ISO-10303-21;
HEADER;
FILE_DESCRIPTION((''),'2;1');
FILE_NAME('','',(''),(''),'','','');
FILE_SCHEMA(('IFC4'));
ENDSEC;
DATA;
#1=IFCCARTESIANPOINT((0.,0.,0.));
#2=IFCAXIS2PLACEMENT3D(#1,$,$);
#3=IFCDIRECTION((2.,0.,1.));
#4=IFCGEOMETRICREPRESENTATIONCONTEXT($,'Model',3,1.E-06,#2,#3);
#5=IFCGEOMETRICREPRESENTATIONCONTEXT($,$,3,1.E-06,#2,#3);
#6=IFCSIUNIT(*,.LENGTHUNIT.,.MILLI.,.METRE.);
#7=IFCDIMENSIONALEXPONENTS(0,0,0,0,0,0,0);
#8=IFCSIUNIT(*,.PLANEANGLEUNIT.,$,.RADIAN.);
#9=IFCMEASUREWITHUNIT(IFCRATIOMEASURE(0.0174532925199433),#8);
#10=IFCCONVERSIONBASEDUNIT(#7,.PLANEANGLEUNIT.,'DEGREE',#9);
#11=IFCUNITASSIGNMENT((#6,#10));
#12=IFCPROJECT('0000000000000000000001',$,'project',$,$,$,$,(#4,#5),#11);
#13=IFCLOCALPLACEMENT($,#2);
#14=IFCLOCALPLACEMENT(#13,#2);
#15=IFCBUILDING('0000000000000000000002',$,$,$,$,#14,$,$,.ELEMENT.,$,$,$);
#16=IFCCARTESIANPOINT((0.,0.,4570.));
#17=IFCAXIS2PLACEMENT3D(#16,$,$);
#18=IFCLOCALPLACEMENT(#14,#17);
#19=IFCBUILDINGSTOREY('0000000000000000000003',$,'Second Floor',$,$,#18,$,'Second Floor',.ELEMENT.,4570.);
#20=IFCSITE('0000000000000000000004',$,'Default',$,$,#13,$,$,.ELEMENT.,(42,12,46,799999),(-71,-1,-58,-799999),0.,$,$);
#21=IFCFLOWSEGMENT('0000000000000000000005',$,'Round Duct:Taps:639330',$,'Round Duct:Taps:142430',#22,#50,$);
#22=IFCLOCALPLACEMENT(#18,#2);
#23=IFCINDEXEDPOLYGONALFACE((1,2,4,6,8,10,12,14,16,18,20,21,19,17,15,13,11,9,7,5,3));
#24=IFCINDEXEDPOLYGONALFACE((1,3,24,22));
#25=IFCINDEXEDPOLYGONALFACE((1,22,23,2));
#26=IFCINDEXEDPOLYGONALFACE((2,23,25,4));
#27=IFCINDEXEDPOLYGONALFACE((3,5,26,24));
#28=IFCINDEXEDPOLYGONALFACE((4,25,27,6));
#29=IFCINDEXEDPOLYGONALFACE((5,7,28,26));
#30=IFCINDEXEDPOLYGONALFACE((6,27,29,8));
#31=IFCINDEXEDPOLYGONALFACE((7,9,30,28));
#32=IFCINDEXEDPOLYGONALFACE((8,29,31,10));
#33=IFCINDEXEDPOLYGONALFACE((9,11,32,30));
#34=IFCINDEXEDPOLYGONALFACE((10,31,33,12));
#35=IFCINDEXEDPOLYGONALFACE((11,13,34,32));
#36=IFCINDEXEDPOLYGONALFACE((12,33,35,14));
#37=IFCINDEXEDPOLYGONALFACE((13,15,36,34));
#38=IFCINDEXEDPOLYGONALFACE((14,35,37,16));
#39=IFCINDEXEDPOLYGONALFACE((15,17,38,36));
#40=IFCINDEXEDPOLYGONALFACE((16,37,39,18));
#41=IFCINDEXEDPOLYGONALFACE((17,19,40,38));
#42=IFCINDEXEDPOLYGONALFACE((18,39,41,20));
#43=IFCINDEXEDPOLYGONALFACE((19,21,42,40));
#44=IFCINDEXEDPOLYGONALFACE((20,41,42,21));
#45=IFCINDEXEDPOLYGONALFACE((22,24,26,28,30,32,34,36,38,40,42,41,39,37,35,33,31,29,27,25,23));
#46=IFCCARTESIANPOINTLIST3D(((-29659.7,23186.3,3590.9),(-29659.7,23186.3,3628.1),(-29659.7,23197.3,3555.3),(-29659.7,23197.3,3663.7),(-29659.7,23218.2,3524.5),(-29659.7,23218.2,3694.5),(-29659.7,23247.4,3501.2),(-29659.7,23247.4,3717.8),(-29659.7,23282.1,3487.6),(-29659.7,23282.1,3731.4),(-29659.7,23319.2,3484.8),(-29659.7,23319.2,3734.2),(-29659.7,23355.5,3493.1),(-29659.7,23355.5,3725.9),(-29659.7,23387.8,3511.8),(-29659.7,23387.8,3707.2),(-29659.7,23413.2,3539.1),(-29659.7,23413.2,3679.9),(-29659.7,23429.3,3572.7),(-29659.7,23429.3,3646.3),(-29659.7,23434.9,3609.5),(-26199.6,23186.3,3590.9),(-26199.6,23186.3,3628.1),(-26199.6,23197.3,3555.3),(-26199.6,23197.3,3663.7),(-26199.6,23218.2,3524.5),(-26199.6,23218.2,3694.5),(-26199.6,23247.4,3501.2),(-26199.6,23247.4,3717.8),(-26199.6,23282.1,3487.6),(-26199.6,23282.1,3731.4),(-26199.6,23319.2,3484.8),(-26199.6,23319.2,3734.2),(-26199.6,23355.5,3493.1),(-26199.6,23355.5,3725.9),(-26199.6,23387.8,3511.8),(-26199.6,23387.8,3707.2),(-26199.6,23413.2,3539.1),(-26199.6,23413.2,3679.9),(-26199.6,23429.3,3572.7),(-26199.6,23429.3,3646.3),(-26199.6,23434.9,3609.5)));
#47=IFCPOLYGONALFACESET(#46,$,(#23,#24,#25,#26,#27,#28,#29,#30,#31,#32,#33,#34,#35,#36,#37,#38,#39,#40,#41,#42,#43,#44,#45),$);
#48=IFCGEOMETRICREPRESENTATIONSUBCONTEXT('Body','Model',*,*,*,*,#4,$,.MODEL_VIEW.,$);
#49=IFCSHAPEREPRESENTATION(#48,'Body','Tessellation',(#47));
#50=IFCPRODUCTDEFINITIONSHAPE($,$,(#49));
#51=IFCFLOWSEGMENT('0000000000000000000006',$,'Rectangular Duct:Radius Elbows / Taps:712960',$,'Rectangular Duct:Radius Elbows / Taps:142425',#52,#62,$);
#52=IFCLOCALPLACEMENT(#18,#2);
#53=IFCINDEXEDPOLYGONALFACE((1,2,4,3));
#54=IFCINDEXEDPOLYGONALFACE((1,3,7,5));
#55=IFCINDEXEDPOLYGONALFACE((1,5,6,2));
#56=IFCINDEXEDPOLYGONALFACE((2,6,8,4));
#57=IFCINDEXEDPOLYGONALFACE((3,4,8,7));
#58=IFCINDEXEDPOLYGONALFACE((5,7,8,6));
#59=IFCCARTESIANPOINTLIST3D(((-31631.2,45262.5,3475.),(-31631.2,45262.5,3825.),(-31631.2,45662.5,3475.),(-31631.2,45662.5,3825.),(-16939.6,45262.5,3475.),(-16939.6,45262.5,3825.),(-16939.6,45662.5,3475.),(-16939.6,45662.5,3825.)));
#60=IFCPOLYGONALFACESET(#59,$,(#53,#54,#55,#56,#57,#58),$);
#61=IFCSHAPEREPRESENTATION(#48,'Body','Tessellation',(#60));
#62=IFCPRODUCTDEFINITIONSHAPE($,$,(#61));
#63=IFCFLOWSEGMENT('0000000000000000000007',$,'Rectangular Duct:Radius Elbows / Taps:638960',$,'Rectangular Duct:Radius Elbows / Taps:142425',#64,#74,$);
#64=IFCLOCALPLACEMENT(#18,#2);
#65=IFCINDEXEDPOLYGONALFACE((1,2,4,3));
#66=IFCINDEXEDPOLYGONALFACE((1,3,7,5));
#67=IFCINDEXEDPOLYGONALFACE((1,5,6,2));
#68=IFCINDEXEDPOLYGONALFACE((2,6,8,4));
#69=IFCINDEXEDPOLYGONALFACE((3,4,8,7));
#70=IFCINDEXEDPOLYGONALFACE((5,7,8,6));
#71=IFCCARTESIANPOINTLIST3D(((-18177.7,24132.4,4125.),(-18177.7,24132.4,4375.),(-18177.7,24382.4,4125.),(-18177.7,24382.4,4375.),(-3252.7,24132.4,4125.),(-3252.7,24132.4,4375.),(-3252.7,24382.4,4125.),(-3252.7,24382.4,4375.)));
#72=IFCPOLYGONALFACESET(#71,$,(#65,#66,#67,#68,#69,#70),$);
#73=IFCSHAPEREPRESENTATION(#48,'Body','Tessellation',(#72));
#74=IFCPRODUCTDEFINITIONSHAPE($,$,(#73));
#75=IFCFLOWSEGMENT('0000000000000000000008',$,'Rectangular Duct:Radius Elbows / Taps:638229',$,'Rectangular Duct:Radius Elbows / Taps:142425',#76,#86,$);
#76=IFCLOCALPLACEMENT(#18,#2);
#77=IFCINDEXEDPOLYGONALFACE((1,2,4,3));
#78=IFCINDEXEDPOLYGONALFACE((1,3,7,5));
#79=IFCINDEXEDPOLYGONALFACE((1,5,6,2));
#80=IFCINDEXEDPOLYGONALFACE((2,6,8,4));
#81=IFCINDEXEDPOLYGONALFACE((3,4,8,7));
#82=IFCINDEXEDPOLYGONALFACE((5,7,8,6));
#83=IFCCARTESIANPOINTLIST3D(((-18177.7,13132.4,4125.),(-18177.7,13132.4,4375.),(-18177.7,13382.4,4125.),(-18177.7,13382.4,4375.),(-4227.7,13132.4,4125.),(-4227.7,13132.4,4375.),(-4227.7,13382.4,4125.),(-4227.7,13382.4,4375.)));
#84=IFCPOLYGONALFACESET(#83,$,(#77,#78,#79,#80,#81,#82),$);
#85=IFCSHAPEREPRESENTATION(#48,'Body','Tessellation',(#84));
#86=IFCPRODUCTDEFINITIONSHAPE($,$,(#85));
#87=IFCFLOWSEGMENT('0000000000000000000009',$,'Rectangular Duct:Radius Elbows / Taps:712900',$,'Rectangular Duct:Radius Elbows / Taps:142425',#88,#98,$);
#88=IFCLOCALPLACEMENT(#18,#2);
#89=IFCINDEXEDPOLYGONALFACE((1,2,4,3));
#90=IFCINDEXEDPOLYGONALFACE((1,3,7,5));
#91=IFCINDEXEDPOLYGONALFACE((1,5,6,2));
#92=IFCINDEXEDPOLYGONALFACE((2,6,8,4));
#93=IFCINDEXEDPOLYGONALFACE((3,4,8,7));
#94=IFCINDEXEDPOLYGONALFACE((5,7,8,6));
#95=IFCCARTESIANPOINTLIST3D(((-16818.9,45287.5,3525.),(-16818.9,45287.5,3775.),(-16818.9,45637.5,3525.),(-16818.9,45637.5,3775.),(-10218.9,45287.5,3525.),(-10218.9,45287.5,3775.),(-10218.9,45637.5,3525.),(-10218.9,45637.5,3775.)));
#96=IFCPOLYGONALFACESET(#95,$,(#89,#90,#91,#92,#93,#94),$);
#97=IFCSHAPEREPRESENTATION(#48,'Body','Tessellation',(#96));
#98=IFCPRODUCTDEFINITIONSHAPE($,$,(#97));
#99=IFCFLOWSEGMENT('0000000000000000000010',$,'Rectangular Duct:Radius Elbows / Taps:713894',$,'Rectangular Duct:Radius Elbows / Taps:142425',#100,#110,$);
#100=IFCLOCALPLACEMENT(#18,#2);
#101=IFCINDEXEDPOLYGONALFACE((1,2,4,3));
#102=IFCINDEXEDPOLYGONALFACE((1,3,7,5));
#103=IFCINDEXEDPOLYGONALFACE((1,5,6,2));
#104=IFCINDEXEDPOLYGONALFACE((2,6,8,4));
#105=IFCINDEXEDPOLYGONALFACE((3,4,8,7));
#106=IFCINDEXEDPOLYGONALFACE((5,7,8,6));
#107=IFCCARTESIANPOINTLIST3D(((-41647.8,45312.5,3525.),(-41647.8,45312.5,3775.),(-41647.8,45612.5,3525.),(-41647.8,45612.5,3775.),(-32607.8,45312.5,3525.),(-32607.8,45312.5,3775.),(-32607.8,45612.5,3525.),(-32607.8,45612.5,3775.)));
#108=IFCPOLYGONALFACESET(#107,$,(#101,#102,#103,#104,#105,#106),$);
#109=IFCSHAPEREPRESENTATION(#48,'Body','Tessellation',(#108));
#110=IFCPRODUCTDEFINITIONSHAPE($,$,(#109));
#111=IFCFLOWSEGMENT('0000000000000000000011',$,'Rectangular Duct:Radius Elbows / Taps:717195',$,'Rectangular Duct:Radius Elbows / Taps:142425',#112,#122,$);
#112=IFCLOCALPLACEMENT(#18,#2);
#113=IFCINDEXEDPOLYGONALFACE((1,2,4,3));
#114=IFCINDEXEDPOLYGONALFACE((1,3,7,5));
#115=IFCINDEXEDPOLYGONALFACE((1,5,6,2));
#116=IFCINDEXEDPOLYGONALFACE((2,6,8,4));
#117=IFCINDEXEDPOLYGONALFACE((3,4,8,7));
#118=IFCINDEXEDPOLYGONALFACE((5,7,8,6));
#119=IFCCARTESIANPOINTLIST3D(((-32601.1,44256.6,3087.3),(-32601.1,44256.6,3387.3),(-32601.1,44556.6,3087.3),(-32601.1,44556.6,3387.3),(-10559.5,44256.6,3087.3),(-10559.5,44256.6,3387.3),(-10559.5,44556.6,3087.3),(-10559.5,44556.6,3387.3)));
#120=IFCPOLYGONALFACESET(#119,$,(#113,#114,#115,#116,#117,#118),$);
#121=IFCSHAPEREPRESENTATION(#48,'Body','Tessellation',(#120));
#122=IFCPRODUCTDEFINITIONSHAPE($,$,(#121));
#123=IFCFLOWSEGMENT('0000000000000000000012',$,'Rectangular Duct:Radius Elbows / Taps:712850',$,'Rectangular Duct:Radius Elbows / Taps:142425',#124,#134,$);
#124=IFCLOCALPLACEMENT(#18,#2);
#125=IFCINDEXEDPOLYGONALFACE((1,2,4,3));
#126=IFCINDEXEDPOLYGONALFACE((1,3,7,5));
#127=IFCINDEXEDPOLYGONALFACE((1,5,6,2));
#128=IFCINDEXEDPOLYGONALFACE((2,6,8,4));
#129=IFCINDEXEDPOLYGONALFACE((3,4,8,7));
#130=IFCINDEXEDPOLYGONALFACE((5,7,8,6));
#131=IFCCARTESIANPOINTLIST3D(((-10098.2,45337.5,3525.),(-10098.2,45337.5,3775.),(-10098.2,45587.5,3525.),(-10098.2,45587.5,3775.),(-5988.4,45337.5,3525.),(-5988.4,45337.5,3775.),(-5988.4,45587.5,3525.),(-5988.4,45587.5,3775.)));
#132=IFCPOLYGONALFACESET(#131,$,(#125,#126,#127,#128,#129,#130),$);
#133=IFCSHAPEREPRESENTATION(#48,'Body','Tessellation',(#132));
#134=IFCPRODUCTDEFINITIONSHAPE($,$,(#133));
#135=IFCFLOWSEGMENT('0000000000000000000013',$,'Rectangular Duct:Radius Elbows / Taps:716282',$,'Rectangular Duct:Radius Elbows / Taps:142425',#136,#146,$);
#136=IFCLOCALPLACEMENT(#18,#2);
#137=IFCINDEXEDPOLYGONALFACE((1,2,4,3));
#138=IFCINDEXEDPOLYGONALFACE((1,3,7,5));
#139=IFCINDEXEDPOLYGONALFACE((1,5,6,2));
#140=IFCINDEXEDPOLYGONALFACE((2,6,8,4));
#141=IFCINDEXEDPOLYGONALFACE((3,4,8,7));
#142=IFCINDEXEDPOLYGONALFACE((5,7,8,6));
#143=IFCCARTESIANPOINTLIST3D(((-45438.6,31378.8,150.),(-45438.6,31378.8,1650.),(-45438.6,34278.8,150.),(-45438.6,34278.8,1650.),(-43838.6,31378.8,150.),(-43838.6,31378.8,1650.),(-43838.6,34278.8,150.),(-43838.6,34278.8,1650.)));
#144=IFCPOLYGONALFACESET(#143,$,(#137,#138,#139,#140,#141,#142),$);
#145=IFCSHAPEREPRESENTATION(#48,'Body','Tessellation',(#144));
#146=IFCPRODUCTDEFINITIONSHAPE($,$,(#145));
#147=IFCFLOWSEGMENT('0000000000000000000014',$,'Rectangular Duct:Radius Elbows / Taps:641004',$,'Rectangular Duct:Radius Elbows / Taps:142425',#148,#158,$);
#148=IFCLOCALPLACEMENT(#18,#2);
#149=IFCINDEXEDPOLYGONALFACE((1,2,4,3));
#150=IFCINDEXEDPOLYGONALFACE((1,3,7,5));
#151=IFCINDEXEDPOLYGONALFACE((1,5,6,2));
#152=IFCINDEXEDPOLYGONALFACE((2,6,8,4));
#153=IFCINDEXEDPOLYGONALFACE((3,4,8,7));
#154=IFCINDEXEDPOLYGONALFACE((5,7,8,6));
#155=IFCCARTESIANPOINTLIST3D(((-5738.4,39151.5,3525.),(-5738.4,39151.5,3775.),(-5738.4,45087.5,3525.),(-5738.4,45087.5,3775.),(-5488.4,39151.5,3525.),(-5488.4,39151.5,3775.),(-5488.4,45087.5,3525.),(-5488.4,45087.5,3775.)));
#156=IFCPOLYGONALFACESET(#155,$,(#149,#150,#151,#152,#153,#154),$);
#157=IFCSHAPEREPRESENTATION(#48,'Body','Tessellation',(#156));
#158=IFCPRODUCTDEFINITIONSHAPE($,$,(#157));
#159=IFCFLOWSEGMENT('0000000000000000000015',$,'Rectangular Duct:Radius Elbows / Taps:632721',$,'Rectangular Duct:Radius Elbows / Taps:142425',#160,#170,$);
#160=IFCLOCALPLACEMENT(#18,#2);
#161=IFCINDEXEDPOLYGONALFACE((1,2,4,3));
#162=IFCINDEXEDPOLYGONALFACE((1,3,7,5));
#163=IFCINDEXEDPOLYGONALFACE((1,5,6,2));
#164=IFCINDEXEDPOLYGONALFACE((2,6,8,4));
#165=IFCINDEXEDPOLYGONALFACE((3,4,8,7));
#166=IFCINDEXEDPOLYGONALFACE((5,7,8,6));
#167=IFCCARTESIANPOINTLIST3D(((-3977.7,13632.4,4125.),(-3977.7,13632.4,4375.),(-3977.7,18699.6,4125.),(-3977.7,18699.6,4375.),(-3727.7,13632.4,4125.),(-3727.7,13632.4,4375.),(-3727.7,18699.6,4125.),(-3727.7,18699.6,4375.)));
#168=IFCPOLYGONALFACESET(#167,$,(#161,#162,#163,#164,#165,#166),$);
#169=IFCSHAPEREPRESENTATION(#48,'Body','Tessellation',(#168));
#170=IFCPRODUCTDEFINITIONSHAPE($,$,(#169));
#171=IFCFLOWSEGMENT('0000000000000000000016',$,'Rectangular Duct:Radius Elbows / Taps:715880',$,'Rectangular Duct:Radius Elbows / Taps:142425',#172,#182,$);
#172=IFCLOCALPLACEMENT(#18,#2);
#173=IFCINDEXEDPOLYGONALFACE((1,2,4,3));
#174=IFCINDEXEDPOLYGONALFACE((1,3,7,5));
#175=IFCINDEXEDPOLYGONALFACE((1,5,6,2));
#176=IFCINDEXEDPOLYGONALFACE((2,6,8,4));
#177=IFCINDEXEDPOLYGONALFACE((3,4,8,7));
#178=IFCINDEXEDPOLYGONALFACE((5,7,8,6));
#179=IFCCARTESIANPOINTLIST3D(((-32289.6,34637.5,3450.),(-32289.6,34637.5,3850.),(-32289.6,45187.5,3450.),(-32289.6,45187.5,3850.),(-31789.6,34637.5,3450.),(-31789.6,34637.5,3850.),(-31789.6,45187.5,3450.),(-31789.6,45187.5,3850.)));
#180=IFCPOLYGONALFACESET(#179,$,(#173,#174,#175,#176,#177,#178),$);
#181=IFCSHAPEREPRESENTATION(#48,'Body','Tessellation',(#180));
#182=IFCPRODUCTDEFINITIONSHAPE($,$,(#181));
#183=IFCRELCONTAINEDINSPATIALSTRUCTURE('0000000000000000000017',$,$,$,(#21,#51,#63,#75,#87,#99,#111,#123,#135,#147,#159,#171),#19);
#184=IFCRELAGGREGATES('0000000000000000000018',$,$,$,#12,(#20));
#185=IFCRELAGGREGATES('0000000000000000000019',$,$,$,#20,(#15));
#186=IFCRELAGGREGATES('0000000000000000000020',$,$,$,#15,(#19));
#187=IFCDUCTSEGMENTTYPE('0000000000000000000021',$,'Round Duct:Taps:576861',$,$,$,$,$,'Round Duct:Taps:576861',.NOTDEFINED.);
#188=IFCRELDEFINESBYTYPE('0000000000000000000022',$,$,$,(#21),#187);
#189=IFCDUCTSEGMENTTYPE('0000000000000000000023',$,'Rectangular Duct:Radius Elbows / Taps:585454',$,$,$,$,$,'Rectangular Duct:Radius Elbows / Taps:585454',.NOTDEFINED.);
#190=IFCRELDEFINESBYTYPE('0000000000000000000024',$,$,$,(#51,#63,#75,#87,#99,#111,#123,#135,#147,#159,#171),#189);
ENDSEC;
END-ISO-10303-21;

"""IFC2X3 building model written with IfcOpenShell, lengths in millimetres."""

from ifc_helpers import new_model, entity, si_unit, converted_unit, direction, frame, frame_2d, origin, origin_2d_with_axis, place, context, subcontext, project, spatial, rectangle, circle, extrude, type_object, element, save


model = new_model("IFC2X3")

# Units and contexts
model_context = context("Model", 3, precision=1e-06, world=origin(), true_north=direction((2.0, 0.0, 1.0)))
context_of_model = context(None, 3, precision=1e-06, world=origin(), true_north=direction((2.0, 0.0, 1.0)))
body_context = subcontext(model_context, "Body", "Model", "MODEL_VIEW")
ifc_project = project(units=[si_unit("LENGTHUNIT", "METRE", prefix="MILLI"), converted_unit("PLANEANGLEUNIT", "DEGREE", entity("IfcRatioMeasure", 0.0174532925199433), si_unit("PLANEANGLEUNIT", "RADIAN"), dimensions=[0, 0, 0, 0, 0, 0, 0])], contexts=[model_context, context_of_model])

# Site, building, storey
site_placement = place(None, origin())
site = spatial("IfcSite", under=ifc_project, at=site_placement, Name="Default", CompositionType="ELEMENT", RefLatitude=(42, 12, 46, 799999), RefLongitude=(-71, -1, -58, -799999), RefElevation=0.0)
building_placement = place(site_placement, origin())
building = spatial("IfcBuilding", under=site, at=building_placement, CompositionType="ELEMENT")
storey_placement = place(building_placement, frame((0.0, 0.0, 4570.0)))
storey = spatial("IfcBuildingStorey", under=building, at=storey_placement, Name="Second Floor", LongName="Second Floor", CompositionType="ELEMENT", Elevation=4570.0)

# Flow segments
duct_segment_type_1 = type_object("IfcDuctSegmentType", Name="Round Duct:Taps:576861", ElementType="Round Duct:Taps:576861", PredefinedType="NOTDEFINED")
flow_segment_1_placement = place(storey_placement, origin())
element("IfcFlowSegment", 1, at=flow_segment_1_placement, inside=storey, type_object=duct_segment_type_1, Name="Round Duct:Taps:639330", ObjectType="Round Duct:Taps:142430", context=body_context, shape_type="SweptSolid", body=[
    extrude(circle(Radius=125.0, at=frame_2d((0.0, 0.0), x_axis=(1.0, 0.0))), frame((-29659.7, 23309.9, 3609.5), z_axis=(1.0, 0.0, 0.0), x_axis=(0.0, 1.0, 0.0)), (0.0, 0.0, 1.0), 3460.1),
])
duct_segment_type_2 = type_object("IfcDuctSegmentType", Name="Rectangular Duct:Radius Elbows / Taps:585454", ElementType="Rectangular Duct:Radius Elbows / Taps:585454", PredefinedType="NOTDEFINED")
flow_segment_2_placement = place(storey_placement, origin())
element("IfcFlowSegment", 2, at=flow_segment_2_placement, inside=storey, type_object=duct_segment_type_2, Name="Rectangular Duct:Radius Elbows / Taps:712960", ObjectType="Rectangular Duct:Radius Elbows / Taps:142425", context=body_context, shape_type="SweptSolid", body=[
    extrude(rectangle(XDim=14691.5, YDim=400.0, at=frame_2d((0.0, 0.0), x_axis=(1.0, 0.0))), frame((-24285.4, 45462.5, 3475.0), z_axis=(0.0, 0.0, 1.0), x_axis=(-1.0, 0.0, 0.0)), (0.0, 0.0, 1.0), 350.0),
])
flow_segment_3_placement = place(storey_placement, origin())
element("IfcFlowSegment", 3, at=flow_segment_3_placement, inside=storey, type_object=duct_segment_type_2, Name="Rectangular Duct:Radius Elbows / Taps:638960", ObjectType="Rectangular Duct:Radius Elbows / Taps:142425", context=body_context, shape_type="SweptSolid", body=[
    extrude(rectangle(XDim=14925.0, YDim=250.0, at=frame_2d((0.0, 0.0), x_axis=(1.0, 0.0))), frame((-10715.2, 24257.4, 4125.0), z_axis=(0.0, 0.0, 1.0), x_axis=(-1.0, 0.0, 0.0)), (0.0, 0.0, 1.0), 250.0),
])
flow_segment_4_placement = place(storey_placement, origin())
element("IfcFlowSegment", 4, at=flow_segment_4_placement, inside=storey, type_object=duct_segment_type_2, Name="Rectangular Duct:Radius Elbows / Taps:638229", ObjectType="Rectangular Duct:Radius Elbows / Taps:142425", context=body_context, shape_type="SweptSolid", body=[
    extrude(rectangle(XDim=13950.0, YDim=250.0, at=frame_2d((0.0, 0.0), x_axis=(1.0, 0.0))), frame((-11202.7, 13257.4, 4125.0), z_axis=(0.0, 0.0, 1.0), x_axis=(-1.0, 0.0, 0.0)), (0.0, 0.0, 1.0), 250.0),
])
flow_segment_5_placement = place(storey_placement, origin())
element("IfcFlowSegment", 5, at=flow_segment_5_placement, inside=storey, type_object=duct_segment_type_2, Name="Rectangular Duct:Radius Elbows / Taps:712900", ObjectType="Rectangular Duct:Radius Elbows / Taps:142425", context=body_context, shape_type="SweptSolid", body=[
    extrude(rectangle(XDim=6600.0, YDim=350.0, at=frame_2d((0.0, 0.0), x_axis=(1.0, 0.0))), frame((-13518.9, 45462.5, 3525.0), z_axis=(0.0, 0.0, 1.0), x_axis=(-1.0, 0.0, 0.0)), (0.0, 0.0, 1.0), 250.0),
])
flow_segment_6_placement = place(storey_placement, origin())
element("IfcFlowSegment", 6, at=flow_segment_6_placement, inside=storey, type_object=duct_segment_type_2, Name="Rectangular Duct:Radius Elbows / Taps:713894", ObjectType="Rectangular Duct:Radius Elbows / Taps:142425", context=body_context, shape_type="SweptSolid", body=[
    extrude(rectangle(XDim=9040.0, YDim=300.0, at=frame_2d((0.0, 0.0), x_axis=(1.0, 0.0))), frame((-37127.8, 45462.5, 3525.0), z_axis=(0.0, 0.0, 1.0), x_axis=(-1.0, 0.0, 0.0)), (0.0, 0.0, 1.0), 250.0),
])
flow_segment_7_placement = place(storey_placement, origin())
element("IfcFlowSegment", 7, at=flow_segment_7_placement, inside=storey, type_object=duct_segment_type_2, Name="Rectangular Duct:Radius Elbows / Taps:717195", ObjectType="Rectangular Duct:Radius Elbows / Taps:142425", context=body_context, shape_type="SweptSolid", body=[
    extrude(rectangle(XDim=22041.6, YDim=300.0, at=origin_2d_with_axis()), frame((-21580.3, 44406.6, 3087.3), z_axis=(0.0, 0.0, 1.0), x_axis=(-1.0, 0.0, 0.0)), (0.0, 0.0, 1.0), 300.0),
])
flow_segment_8_placement = place(storey_placement, origin())
element("IfcFlowSegment", 8, at=flow_segment_8_placement, inside=storey, type_object=duct_segment_type_2, Name="Rectangular Duct:Radius Elbows / Taps:712850", ObjectType="Rectangular Duct:Radius Elbows / Taps:142425", context=body_context, shape_type="SweptSolid", body=[
    extrude(rectangle(XDim=4109.8, YDim=250.0, at=frame_2d((0.0, 0.0), x_axis=(1.0, 0.0))), frame((-8043.3, 45462.5, 3525.0), z_axis=(0.0, 0.0, 1.0), x_axis=(-1.0, 0.0, 0.0)), (0.0, 0.0, 1.0), 250.0),
])
flow_segment_9_placement = place(storey_placement, origin())
element("IfcFlowSegment", 9, at=flow_segment_9_placement, inside=storey, type_object=duct_segment_type_2, Name="Rectangular Duct:Radius Elbows / Taps:716282", ObjectType="Rectangular Duct:Radius Elbows / Taps:142425", context=body_context, shape_type="SweptSolid", body=[
    extrude(rectangle(XDim=1600.0, YDim=2900.0, at=frame_2d((0.0, 0.0), x_axis=(1.0, 0.0))), frame((-44638.6, 32828.8, 150.0), z_axis=(0.0, 0.0, 1.0), x_axis=(-1.0, 0.0, 0.0)), (0.0, 0.0, 1.0), 1500.0),
])
flow_segment_10_placement = place(storey_placement, origin())
element("IfcFlowSegment", 10, at=flow_segment_10_placement, inside=storey, type_object=duct_segment_type_2, Name="Rectangular Duct:Radius Elbows / Taps:641004", ObjectType="Rectangular Duct:Radius Elbows / Taps:142425", context=body_context, shape_type="SweptSolid", body=[
    extrude(rectangle(XDim=5935.9, YDim=250.0, at=frame_2d((0.0, 0.0), x_axis=(1.0, 0.0))), frame((-5613.4, 42119.5, 3525.0), z_axis=(0.0, 0.0, 1.0), x_axis=(0.0, 1.0, 0.0)), (0.0, 0.0, 1.0), 250.0),
])
flow_segment_11_placement = place(storey_placement, origin())
element("IfcFlowSegment", 11, at=flow_segment_11_placement, inside=storey, type_object=duct_segment_type_2, Name="Rectangular Duct:Radius Elbows / Taps:632721", ObjectType="Rectangular Duct:Radius Elbows / Taps:142425", context=body_context, shape_type="SweptSolid", body=[
    extrude(rectangle(XDim=5067.2, YDim=250.0, at=frame_2d((0.0, 0.0), x_axis=(1.0, 0.0))), frame((-3852.7, 16166.0, 4125.0), z_axis=(0.0, 0.0, 1.0), x_axis=(0.0, 1.0, 0.0)), (0.0, 0.0, 1.0), 250.0),
])
flow_segment_12_placement = place(storey_placement, origin())
element("IfcFlowSegment", 12, at=flow_segment_12_placement, inside=storey, type_object=duct_segment_type_2, Name="Rectangular Duct:Radius Elbows / Taps:715880", ObjectType="Rectangular Duct:Radius Elbows / Taps:142425", context=body_context, shape_type="SweptSolid", body=[
    extrude(rectangle(XDim=10550.0, YDim=500.0, at=frame_2d((0.0, 0.0), x_axis=(1.0, 0.0))), frame((-32039.6, 39912.5, 3450.0), z_axis=(0.0, 0.0, 1.0), x_axis=(0.0, -1.0, 0.0)), (0.0, 0.0, 1.0), 400.0),
])

save(model, "model.ifc")
